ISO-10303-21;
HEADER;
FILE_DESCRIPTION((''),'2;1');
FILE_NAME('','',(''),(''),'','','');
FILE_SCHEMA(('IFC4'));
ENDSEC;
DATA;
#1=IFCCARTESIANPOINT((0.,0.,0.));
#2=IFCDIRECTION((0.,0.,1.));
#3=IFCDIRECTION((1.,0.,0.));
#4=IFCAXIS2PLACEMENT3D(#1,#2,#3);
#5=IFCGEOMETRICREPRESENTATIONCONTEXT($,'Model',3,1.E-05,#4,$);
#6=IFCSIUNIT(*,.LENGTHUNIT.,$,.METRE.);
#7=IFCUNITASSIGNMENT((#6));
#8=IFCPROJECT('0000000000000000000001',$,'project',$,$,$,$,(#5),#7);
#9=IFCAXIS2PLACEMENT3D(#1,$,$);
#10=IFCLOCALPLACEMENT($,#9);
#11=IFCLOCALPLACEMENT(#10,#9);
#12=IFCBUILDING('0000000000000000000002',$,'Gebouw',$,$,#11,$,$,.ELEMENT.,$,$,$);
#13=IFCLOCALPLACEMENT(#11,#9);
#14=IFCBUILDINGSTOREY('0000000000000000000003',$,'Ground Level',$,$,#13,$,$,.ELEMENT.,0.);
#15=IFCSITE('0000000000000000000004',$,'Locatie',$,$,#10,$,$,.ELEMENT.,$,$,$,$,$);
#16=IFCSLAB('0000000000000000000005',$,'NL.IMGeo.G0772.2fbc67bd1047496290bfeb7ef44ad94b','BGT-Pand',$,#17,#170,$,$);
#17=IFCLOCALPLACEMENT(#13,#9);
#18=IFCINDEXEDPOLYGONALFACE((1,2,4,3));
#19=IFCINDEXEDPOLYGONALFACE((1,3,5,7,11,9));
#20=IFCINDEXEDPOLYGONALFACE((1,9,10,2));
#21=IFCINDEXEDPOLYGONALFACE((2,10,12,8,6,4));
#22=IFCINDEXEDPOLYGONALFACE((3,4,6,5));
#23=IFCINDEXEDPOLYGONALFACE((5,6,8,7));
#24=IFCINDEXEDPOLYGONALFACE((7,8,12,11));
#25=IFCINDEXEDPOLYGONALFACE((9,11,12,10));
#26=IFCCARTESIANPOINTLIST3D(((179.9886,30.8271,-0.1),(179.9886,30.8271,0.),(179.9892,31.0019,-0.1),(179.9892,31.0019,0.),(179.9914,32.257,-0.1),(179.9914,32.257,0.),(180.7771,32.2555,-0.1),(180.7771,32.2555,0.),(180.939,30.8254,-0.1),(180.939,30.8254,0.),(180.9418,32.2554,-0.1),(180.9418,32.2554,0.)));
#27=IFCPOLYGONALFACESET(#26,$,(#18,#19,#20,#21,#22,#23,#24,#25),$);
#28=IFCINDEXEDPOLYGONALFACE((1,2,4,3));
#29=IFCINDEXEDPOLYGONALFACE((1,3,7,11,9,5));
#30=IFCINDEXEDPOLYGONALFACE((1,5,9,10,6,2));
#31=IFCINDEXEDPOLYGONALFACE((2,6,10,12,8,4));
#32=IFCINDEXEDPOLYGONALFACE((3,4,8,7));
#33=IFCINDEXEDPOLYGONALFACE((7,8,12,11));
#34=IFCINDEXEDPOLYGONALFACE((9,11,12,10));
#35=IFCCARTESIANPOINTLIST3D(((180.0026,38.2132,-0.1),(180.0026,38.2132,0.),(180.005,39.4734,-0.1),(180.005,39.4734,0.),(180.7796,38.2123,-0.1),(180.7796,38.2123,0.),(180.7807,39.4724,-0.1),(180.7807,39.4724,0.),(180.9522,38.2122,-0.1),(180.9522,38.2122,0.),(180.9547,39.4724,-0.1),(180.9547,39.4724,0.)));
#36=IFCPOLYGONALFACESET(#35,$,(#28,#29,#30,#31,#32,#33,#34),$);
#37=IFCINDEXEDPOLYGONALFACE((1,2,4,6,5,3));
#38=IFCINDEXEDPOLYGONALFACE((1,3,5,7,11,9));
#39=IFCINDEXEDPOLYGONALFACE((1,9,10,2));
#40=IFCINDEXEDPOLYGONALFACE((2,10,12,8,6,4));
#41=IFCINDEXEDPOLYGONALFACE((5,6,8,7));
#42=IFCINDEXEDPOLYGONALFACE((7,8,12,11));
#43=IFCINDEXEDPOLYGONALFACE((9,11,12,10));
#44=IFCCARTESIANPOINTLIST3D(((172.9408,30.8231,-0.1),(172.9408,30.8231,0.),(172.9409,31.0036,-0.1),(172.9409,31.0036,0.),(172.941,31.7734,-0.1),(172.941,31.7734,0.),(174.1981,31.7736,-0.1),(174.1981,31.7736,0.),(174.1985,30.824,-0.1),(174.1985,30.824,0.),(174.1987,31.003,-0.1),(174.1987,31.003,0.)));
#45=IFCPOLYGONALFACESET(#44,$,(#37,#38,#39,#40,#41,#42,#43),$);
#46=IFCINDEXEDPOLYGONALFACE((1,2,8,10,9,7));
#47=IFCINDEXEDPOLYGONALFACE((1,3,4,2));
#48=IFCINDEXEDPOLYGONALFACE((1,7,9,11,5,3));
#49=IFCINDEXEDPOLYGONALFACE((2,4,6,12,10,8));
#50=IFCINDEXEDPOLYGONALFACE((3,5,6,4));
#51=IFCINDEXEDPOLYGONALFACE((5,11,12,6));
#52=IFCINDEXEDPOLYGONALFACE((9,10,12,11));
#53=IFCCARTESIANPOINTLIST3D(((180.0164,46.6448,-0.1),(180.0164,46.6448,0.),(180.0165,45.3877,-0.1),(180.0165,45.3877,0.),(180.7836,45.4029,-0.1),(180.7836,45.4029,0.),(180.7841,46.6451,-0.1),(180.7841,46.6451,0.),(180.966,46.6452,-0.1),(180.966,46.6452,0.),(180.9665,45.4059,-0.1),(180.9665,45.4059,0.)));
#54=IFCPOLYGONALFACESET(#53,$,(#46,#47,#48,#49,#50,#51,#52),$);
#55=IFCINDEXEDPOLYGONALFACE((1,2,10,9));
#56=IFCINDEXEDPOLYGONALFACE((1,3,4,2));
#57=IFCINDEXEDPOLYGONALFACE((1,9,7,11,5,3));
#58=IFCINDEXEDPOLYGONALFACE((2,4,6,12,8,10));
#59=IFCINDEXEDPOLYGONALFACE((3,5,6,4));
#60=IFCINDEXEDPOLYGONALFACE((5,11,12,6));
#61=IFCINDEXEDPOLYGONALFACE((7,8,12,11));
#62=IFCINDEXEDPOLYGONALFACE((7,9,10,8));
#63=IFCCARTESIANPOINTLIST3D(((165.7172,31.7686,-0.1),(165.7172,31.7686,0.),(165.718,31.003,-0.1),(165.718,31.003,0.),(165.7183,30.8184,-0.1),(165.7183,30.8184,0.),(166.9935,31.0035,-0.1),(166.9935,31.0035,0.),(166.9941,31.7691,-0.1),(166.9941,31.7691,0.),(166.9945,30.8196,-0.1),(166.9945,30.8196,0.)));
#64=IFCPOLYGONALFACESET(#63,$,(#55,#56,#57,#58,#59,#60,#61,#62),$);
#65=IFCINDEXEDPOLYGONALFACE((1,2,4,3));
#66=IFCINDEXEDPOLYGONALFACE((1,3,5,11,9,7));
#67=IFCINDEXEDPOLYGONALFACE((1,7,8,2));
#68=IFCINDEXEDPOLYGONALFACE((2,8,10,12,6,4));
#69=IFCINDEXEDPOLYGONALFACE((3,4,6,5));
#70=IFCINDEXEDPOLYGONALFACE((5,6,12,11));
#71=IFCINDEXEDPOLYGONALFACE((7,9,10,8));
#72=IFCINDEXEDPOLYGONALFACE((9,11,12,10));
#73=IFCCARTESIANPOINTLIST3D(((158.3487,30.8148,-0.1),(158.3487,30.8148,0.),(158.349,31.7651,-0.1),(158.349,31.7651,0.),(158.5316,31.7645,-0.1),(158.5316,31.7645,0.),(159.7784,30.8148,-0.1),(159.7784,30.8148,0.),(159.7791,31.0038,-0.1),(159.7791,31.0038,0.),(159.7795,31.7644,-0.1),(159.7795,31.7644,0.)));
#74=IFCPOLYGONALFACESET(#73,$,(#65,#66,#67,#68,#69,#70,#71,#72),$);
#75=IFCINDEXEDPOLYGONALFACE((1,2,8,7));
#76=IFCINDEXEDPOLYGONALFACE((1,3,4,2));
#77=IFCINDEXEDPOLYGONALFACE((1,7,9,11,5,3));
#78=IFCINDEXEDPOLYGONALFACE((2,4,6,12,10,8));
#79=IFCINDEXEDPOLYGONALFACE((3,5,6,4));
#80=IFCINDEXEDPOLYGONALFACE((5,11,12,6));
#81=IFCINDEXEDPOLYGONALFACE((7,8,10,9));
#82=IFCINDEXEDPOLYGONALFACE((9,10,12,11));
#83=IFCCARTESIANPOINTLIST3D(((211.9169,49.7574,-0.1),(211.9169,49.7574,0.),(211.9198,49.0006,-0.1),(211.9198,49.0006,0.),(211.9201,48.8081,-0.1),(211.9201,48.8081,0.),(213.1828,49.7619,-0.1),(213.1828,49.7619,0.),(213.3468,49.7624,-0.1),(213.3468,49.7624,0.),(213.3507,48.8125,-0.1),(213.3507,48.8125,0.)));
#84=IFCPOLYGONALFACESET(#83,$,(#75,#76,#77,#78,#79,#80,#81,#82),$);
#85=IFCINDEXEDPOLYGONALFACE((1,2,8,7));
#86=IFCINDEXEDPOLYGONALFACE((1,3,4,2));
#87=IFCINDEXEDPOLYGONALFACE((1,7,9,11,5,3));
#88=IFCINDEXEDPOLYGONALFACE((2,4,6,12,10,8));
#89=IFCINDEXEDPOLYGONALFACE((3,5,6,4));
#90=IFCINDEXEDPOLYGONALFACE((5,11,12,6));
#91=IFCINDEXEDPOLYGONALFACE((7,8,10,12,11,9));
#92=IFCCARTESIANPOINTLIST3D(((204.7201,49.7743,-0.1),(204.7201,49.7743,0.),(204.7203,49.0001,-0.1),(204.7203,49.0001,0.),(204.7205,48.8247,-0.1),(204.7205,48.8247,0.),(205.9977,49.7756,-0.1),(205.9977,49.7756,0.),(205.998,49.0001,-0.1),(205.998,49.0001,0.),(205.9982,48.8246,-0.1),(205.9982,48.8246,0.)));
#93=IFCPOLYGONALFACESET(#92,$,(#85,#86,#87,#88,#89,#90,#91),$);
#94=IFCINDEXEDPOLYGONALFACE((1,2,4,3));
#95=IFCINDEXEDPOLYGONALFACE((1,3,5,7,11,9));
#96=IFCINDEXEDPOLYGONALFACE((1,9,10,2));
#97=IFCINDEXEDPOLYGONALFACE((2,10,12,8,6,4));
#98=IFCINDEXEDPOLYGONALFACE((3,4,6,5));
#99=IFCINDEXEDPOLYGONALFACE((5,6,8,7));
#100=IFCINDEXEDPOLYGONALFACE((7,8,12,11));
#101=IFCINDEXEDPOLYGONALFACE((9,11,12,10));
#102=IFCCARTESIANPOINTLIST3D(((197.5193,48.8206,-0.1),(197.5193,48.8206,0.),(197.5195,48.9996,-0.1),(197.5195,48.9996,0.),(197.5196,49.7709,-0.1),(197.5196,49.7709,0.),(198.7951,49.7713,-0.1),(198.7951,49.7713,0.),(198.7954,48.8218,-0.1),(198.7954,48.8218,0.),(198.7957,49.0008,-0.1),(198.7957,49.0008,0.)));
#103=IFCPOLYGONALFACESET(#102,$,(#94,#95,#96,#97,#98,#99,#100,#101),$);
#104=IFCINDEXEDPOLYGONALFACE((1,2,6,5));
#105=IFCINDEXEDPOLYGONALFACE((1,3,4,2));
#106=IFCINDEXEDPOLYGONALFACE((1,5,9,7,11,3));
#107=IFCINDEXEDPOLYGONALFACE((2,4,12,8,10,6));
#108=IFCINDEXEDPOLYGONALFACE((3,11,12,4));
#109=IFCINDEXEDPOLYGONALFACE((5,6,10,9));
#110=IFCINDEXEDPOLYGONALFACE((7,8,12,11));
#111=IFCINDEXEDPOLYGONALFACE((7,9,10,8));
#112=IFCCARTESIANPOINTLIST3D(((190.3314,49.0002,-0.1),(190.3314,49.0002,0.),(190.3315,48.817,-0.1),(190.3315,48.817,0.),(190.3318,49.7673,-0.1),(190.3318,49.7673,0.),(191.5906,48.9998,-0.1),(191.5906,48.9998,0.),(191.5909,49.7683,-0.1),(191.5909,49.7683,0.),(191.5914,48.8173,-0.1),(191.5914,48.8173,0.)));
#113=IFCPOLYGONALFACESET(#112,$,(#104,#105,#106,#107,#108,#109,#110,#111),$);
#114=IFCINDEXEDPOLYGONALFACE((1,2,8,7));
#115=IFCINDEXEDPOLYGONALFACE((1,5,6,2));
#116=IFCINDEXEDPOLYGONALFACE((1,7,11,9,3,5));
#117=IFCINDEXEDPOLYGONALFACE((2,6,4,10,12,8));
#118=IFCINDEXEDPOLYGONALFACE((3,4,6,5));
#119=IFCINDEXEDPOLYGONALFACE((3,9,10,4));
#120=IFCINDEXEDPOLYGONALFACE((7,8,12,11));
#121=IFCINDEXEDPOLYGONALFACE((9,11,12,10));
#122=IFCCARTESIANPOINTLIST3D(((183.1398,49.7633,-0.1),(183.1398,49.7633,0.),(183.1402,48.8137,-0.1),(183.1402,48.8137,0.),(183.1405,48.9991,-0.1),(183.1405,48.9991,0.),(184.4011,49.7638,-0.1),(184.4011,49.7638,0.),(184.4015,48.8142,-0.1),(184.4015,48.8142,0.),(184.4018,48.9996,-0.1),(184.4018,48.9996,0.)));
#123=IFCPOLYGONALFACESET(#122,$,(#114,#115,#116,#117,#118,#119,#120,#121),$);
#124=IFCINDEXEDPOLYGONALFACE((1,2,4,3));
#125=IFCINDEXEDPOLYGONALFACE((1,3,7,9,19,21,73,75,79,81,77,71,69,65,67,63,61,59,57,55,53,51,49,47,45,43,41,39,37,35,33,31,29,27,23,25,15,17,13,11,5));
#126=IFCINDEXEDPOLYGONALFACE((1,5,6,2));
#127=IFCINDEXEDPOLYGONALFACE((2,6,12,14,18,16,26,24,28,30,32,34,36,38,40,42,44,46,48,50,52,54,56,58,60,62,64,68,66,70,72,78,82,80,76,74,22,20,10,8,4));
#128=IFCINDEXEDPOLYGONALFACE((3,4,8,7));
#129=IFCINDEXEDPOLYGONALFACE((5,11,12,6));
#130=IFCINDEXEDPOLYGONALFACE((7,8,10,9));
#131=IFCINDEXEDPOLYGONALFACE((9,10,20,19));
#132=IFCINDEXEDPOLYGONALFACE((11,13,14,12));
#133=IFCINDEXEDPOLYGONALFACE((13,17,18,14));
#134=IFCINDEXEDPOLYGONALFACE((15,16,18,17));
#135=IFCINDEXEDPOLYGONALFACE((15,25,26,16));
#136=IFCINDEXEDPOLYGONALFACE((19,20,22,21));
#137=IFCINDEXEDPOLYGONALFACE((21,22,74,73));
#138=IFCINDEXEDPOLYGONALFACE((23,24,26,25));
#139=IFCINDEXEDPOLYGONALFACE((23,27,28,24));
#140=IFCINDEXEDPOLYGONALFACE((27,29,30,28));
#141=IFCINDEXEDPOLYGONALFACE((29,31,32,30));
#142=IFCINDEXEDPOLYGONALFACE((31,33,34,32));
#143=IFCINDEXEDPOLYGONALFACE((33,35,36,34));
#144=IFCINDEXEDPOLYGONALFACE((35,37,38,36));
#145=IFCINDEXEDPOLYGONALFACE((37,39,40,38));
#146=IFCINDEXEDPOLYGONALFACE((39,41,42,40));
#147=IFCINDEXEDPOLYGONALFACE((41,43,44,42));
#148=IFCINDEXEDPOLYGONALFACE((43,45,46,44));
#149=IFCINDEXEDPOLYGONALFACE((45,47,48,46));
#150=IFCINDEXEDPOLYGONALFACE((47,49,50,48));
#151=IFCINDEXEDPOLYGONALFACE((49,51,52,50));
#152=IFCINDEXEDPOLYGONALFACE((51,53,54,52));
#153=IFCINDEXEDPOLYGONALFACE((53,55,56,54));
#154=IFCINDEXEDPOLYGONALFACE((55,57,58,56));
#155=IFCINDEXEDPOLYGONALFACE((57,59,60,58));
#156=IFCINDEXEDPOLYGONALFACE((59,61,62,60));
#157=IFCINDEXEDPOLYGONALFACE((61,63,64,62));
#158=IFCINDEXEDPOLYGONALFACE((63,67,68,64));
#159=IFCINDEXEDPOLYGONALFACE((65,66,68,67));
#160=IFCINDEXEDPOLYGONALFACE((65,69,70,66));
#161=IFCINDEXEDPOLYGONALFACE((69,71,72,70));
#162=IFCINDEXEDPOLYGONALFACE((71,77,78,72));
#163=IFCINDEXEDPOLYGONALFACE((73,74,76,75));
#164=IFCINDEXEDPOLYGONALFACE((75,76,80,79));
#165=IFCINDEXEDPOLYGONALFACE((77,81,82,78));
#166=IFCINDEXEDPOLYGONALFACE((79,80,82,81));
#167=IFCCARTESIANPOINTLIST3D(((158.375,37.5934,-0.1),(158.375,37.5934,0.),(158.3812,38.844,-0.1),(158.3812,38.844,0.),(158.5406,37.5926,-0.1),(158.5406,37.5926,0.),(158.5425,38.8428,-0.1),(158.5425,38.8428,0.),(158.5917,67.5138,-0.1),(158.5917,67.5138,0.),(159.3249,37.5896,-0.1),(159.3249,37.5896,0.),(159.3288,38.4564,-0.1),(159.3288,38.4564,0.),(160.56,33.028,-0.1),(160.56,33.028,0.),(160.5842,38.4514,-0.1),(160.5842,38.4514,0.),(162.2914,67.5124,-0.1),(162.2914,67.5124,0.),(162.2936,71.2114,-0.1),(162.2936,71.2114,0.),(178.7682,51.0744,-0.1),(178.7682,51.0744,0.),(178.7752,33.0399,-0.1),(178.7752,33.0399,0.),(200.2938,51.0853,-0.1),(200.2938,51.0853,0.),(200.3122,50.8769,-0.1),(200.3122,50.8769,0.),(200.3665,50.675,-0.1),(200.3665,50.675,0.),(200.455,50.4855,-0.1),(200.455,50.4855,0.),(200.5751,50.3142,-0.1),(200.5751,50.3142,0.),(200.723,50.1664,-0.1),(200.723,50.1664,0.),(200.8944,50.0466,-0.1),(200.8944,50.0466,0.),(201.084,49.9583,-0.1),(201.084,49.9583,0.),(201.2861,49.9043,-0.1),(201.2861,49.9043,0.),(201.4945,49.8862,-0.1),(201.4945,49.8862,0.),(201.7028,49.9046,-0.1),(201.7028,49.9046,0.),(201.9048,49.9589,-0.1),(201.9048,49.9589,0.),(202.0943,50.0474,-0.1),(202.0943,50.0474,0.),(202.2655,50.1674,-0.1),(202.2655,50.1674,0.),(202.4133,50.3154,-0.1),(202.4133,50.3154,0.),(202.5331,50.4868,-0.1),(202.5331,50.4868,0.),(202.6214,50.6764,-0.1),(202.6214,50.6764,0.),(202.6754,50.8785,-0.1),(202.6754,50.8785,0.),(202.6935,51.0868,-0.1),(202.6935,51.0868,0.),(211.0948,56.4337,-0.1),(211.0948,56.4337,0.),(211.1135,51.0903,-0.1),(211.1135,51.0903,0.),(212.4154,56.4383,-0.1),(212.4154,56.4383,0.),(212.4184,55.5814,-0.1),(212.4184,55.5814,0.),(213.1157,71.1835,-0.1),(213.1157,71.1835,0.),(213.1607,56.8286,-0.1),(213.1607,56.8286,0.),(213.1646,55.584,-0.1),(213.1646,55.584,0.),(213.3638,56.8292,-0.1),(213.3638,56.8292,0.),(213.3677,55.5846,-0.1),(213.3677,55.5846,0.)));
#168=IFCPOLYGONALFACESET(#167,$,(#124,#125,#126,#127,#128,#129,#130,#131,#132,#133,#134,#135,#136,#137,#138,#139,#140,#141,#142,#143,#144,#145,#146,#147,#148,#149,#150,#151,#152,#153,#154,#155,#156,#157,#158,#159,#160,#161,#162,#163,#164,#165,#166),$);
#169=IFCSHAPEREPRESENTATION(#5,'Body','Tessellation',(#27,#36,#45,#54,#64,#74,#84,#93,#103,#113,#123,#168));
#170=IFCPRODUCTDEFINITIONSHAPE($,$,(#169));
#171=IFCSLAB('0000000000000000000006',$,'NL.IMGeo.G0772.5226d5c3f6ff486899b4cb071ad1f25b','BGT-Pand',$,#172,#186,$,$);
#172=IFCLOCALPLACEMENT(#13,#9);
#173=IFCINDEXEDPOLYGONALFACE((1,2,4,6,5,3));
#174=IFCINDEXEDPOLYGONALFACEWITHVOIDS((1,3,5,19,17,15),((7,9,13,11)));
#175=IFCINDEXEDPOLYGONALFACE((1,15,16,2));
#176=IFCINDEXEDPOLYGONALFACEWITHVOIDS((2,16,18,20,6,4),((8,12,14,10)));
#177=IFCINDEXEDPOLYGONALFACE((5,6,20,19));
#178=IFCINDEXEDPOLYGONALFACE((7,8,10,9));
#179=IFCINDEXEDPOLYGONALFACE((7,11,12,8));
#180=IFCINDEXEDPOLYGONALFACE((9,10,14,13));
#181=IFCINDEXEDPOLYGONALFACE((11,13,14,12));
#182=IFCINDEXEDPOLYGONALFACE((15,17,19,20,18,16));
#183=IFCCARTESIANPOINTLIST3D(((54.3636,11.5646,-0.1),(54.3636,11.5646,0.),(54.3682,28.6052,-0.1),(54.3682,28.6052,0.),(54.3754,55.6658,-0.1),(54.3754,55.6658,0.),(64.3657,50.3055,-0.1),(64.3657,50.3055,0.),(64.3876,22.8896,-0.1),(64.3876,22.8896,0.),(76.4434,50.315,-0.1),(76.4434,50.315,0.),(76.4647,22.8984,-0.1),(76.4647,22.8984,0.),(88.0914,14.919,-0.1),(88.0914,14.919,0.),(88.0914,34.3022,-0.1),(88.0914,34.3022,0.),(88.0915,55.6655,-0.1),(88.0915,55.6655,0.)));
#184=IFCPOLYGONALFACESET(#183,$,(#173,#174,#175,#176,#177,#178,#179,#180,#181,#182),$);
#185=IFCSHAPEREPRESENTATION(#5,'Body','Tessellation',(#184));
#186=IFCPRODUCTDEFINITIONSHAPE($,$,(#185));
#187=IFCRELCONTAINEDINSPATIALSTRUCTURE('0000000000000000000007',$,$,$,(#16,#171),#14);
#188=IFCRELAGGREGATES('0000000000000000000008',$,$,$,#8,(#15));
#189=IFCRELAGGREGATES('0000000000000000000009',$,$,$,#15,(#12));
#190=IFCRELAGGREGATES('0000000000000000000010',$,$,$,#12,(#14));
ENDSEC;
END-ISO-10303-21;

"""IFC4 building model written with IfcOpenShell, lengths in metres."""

from ifc_helpers import new_model, si_unit, frame, origin, origin_with_axes, place, context, project, spatial, polyline, outline, extrude, element, save


model = new_model("IFC4")

# Units and contexts
model_context = context("Model", 3, precision=1e-05, world=origin_with_axes())
ifc_project = project(units=[si_unit("LENGTHUNIT", "METRE")], contexts=[model_context])

# Site, building, storey
site_placement = place(None, origin())
site = spatial("IfcSite", under=ifc_project, at=site_placement, Name="Locatie", CompositionType="ELEMENT")
building_placement = place(site_placement, origin())
building = spatial("IfcBuilding", under=site, at=building_placement, Name="Gebouw", CompositionType="ELEMENT")
storey_placement = place(building_placement, origin())
storey = spatial("IfcBuildingStorey", under=building, at=storey_placement, Name="Ground Level", CompositionType="ELEMENT", Elevation=0.0)

# Slabs
slab_1_placement = place(storey_placement, origin())
element("IfcSlab", 1, at=slab_1_placement, inside=storey, Name="NL.IMGeo.G0772.2fbc67bd1047496290bfeb7ef44ad94b", Description="BGT-Pand", context=model_context, shape_type="SweptSolid", body=[
    extrude(outline(polyline([(179.9914, 32.257), (180.7771, 32.2555), (180.9418, 32.2554), (180.939, 30.8254), (179.9886, 30.8271), (179.9892, 31.0019), (179.9914, 32.257)])), frame((0.0, 0.0, -0.1), z_axis=(0.0, 0.0, 1.0), x_axis=(1.0, 0.0, 0.0)), (0.0, 0.0, 1.0), 0.1),
    extrude(outline(polyline([(180.0026, 38.2132), (180.005, 39.4734), (180.7807, 39.4724), (180.9547, 39.4724), (180.9522, 38.2122), (180.7796, 38.2123), (180.0026, 38.2132)])), frame((0.0, 0.0, -0.1), z_axis=(0.0, 0.0, 1.0), x_axis=(1.0, 0.0, 0.0)), (0.0, 0.0, 1.0), 0.1),
    extrude(outline(polyline([(172.9409, 31.0036), (172.941, 31.7734), (174.1981, 31.7736), (174.1987, 31.003), (174.1985, 30.824), (172.9408, 30.8231), (172.9409, 31.0036)])), frame((0.0, 0.0, -0.1), z_axis=(0.0, 0.0, 1.0), x_axis=(1.0, 0.0, 0.0)), (0.0, 0.0, 1.0), 0.1),
    extrude(outline(polyline([(180.7836, 45.4029), (180.0165, 45.3877), (180.0164, 46.6448), (180.7841, 46.6451), (180.966, 46.6452), (180.9665, 45.4059), (180.7836, 45.4029)])), frame((0.0, 0.0, -0.1), z_axis=(0.0, 0.0, 1.0), x_axis=(1.0, 0.0, 0.0)), (0.0, 0.0, 1.0), 0.1),
    extrude(outline(polyline([(165.718, 31.003), (165.7172, 31.7686), (166.9941, 31.7691), (166.9935, 31.0035), (166.9945, 30.8196), (165.7183, 30.8184), (165.718, 31.003)])), frame((0.0, 0.0, -0.1), z_axis=(0.0, 0.0, 1.0), x_axis=(1.0, 0.0, 0.0)), (0.0, 0.0, 1.0), 0.1),
    extrude(outline(polyline([(159.7791, 31.0038), (159.7784, 30.8148), (158.3487, 30.8148), (158.349, 31.7651), (158.5316, 31.7645), (159.7795, 31.7644), (159.7791, 31.0038)])), frame((0.0, 0.0, -0.1), z_axis=(0.0, 0.0, 1.0), x_axis=(1.0, 0.0, 0.0)), (0.0, 0.0, 1.0), 0.1),
    extrude(outline(polyline([(211.9201, 48.8081), (211.9198, 49.0006), (211.9169, 49.7574), (213.1828, 49.7619), (213.3468, 49.7624), (213.3507, 48.8125), (211.9201, 48.8081)])), frame((0.0, 0.0, -0.1), z_axis=(0.0, 0.0, 1.0), x_axis=(1.0, 0.0, 0.0)), (0.0, 0.0, 1.0), 0.1),
    extrude(outline(polyline([(204.7203, 49.0001), (204.7201, 49.7743), (205.9977, 49.7756), (205.998, 49.0001), (205.9982, 48.8246), (204.7205, 48.8247), (204.7203, 49.0001)])), frame((0.0, 0.0, -0.1), z_axis=(0.0, 0.0, 1.0), x_axis=(1.0, 0.0, 0.0)), (0.0, 0.0, 1.0), 0.1),
    extrude(outline(polyline([(197.5195, 48.9996), (197.5196, 49.7709), (198.7951, 49.7713), (198.7957, 49.0008), (198.7954, 48.8218), (197.5193, 48.8206), (197.5195, 48.9996)])), frame((0.0, 0.0, -0.1), z_axis=(0.0, 0.0, 1.0), x_axis=(1.0, 0.0, 0.0)), (0.0, 0.0, 1.0), 0.1),
    extrude(outline(polyline([(190.3315, 48.817), (190.3314, 49.0002), (190.3318, 49.7673), (191.5909, 49.7683), (191.5906, 48.9998), (191.5914, 48.8173), (190.3315, 48.817)])), frame((0.0, 0.0, -0.1), z_axis=(0.0, 0.0, 1.0), x_axis=(1.0, 0.0, 0.0)), (0.0, 0.0, 1.0), 0.1),
    extrude(outline(polyline([(183.1405, 48.9991), (183.1398, 49.7633), (184.4011, 49.7638), (184.4018, 48.9996), (184.4015, 48.8142), (183.1402, 48.8137), (183.1405, 48.9991)])), frame((0.0, 0.0, -0.1), z_axis=(0.0, 0.0, 1.0), x_axis=(1.0, 0.0, 0.0)), (0.0, 0.0, 1.0), 0.1),
    extrude(outline(polyline([(213.1646, 55.584), (212.4184, 55.5814), (212.4154, 56.4383), (211.0948, 56.4337), (211.1135, 51.0903), (202.6935, 51.0868), (202.6754, 50.8785), (202.6214, 50.6764), (202.5331, 50.4868), (202.4133, 50.3154), (202.2655, 50.1674), (202.0943, 50.0474), (201.9048, 49.9589), (201.7028, 49.9046), (201.4945, 49.8862), (201.2861, 49.9043), (201.084, 49.9583), (200.8944, 50.0466), (200.723, 50.1664), (200.5751, 50.3142), (200.455, 50.4855), (200.3665, 50.675), (200.3122, 50.8769), (200.2938, 51.0853), (178.7682, 51.0744), (178.7752, 33.0399), (160.56, 33.028), (160.5842, 38.4514), (159.3288, 38.4564), (159.3249, 37.5896), (158.5406, 37.5926), (158.375, 37.5934), (158.3812, 38.844), (158.5425, 38.8428), (158.5917, 67.5138), (162.2914, 67.5124), (162.2936, 71.2114), (213.1157, 71.1835), (213.1607, 56.8286), (213.3638, 56.8292), (213.3677, 55.5846), (213.1646, 55.584)])), frame((0.0, 0.0, -0.1), z_axis=(0.0, 0.0, 1.0), x_axis=(1.0, 0.0, 0.0)), (0.0, 0.0, 1.0), 0.1),
])
slab_2_placement = place(storey_placement, origin())
element("IfcSlab", 2, at=slab_2_placement, inside=storey, Name="NL.IMGeo.G0772.5226d5c3f6ff486899b4cb071ad1f25b", Description="BGT-Pand", context=model_context, shape_type="SweptSolid", body=[
    extrude(outline(polyline([(88.0915, 55.6655), (88.0914, 34.3022), (88.0914, 14.919), (54.3636, 11.5646), (54.3682, 28.6052), (54.3754, 55.6658), (88.0915, 55.6655)]), holes=[polyline([(76.4434, 50.315), (64.3657, 50.3055), (64.3876, 22.8896), (76.4647, 22.8984), (76.4434, 50.315)])]), frame((0.0, 0.0, -0.1), z_axis=(0.0, 0.0, 1.0), x_axis=(1.0, 0.0, 0.0)), (0.0, 0.0, 1.0), 0.1),
])

save(model, "model.ifc")
